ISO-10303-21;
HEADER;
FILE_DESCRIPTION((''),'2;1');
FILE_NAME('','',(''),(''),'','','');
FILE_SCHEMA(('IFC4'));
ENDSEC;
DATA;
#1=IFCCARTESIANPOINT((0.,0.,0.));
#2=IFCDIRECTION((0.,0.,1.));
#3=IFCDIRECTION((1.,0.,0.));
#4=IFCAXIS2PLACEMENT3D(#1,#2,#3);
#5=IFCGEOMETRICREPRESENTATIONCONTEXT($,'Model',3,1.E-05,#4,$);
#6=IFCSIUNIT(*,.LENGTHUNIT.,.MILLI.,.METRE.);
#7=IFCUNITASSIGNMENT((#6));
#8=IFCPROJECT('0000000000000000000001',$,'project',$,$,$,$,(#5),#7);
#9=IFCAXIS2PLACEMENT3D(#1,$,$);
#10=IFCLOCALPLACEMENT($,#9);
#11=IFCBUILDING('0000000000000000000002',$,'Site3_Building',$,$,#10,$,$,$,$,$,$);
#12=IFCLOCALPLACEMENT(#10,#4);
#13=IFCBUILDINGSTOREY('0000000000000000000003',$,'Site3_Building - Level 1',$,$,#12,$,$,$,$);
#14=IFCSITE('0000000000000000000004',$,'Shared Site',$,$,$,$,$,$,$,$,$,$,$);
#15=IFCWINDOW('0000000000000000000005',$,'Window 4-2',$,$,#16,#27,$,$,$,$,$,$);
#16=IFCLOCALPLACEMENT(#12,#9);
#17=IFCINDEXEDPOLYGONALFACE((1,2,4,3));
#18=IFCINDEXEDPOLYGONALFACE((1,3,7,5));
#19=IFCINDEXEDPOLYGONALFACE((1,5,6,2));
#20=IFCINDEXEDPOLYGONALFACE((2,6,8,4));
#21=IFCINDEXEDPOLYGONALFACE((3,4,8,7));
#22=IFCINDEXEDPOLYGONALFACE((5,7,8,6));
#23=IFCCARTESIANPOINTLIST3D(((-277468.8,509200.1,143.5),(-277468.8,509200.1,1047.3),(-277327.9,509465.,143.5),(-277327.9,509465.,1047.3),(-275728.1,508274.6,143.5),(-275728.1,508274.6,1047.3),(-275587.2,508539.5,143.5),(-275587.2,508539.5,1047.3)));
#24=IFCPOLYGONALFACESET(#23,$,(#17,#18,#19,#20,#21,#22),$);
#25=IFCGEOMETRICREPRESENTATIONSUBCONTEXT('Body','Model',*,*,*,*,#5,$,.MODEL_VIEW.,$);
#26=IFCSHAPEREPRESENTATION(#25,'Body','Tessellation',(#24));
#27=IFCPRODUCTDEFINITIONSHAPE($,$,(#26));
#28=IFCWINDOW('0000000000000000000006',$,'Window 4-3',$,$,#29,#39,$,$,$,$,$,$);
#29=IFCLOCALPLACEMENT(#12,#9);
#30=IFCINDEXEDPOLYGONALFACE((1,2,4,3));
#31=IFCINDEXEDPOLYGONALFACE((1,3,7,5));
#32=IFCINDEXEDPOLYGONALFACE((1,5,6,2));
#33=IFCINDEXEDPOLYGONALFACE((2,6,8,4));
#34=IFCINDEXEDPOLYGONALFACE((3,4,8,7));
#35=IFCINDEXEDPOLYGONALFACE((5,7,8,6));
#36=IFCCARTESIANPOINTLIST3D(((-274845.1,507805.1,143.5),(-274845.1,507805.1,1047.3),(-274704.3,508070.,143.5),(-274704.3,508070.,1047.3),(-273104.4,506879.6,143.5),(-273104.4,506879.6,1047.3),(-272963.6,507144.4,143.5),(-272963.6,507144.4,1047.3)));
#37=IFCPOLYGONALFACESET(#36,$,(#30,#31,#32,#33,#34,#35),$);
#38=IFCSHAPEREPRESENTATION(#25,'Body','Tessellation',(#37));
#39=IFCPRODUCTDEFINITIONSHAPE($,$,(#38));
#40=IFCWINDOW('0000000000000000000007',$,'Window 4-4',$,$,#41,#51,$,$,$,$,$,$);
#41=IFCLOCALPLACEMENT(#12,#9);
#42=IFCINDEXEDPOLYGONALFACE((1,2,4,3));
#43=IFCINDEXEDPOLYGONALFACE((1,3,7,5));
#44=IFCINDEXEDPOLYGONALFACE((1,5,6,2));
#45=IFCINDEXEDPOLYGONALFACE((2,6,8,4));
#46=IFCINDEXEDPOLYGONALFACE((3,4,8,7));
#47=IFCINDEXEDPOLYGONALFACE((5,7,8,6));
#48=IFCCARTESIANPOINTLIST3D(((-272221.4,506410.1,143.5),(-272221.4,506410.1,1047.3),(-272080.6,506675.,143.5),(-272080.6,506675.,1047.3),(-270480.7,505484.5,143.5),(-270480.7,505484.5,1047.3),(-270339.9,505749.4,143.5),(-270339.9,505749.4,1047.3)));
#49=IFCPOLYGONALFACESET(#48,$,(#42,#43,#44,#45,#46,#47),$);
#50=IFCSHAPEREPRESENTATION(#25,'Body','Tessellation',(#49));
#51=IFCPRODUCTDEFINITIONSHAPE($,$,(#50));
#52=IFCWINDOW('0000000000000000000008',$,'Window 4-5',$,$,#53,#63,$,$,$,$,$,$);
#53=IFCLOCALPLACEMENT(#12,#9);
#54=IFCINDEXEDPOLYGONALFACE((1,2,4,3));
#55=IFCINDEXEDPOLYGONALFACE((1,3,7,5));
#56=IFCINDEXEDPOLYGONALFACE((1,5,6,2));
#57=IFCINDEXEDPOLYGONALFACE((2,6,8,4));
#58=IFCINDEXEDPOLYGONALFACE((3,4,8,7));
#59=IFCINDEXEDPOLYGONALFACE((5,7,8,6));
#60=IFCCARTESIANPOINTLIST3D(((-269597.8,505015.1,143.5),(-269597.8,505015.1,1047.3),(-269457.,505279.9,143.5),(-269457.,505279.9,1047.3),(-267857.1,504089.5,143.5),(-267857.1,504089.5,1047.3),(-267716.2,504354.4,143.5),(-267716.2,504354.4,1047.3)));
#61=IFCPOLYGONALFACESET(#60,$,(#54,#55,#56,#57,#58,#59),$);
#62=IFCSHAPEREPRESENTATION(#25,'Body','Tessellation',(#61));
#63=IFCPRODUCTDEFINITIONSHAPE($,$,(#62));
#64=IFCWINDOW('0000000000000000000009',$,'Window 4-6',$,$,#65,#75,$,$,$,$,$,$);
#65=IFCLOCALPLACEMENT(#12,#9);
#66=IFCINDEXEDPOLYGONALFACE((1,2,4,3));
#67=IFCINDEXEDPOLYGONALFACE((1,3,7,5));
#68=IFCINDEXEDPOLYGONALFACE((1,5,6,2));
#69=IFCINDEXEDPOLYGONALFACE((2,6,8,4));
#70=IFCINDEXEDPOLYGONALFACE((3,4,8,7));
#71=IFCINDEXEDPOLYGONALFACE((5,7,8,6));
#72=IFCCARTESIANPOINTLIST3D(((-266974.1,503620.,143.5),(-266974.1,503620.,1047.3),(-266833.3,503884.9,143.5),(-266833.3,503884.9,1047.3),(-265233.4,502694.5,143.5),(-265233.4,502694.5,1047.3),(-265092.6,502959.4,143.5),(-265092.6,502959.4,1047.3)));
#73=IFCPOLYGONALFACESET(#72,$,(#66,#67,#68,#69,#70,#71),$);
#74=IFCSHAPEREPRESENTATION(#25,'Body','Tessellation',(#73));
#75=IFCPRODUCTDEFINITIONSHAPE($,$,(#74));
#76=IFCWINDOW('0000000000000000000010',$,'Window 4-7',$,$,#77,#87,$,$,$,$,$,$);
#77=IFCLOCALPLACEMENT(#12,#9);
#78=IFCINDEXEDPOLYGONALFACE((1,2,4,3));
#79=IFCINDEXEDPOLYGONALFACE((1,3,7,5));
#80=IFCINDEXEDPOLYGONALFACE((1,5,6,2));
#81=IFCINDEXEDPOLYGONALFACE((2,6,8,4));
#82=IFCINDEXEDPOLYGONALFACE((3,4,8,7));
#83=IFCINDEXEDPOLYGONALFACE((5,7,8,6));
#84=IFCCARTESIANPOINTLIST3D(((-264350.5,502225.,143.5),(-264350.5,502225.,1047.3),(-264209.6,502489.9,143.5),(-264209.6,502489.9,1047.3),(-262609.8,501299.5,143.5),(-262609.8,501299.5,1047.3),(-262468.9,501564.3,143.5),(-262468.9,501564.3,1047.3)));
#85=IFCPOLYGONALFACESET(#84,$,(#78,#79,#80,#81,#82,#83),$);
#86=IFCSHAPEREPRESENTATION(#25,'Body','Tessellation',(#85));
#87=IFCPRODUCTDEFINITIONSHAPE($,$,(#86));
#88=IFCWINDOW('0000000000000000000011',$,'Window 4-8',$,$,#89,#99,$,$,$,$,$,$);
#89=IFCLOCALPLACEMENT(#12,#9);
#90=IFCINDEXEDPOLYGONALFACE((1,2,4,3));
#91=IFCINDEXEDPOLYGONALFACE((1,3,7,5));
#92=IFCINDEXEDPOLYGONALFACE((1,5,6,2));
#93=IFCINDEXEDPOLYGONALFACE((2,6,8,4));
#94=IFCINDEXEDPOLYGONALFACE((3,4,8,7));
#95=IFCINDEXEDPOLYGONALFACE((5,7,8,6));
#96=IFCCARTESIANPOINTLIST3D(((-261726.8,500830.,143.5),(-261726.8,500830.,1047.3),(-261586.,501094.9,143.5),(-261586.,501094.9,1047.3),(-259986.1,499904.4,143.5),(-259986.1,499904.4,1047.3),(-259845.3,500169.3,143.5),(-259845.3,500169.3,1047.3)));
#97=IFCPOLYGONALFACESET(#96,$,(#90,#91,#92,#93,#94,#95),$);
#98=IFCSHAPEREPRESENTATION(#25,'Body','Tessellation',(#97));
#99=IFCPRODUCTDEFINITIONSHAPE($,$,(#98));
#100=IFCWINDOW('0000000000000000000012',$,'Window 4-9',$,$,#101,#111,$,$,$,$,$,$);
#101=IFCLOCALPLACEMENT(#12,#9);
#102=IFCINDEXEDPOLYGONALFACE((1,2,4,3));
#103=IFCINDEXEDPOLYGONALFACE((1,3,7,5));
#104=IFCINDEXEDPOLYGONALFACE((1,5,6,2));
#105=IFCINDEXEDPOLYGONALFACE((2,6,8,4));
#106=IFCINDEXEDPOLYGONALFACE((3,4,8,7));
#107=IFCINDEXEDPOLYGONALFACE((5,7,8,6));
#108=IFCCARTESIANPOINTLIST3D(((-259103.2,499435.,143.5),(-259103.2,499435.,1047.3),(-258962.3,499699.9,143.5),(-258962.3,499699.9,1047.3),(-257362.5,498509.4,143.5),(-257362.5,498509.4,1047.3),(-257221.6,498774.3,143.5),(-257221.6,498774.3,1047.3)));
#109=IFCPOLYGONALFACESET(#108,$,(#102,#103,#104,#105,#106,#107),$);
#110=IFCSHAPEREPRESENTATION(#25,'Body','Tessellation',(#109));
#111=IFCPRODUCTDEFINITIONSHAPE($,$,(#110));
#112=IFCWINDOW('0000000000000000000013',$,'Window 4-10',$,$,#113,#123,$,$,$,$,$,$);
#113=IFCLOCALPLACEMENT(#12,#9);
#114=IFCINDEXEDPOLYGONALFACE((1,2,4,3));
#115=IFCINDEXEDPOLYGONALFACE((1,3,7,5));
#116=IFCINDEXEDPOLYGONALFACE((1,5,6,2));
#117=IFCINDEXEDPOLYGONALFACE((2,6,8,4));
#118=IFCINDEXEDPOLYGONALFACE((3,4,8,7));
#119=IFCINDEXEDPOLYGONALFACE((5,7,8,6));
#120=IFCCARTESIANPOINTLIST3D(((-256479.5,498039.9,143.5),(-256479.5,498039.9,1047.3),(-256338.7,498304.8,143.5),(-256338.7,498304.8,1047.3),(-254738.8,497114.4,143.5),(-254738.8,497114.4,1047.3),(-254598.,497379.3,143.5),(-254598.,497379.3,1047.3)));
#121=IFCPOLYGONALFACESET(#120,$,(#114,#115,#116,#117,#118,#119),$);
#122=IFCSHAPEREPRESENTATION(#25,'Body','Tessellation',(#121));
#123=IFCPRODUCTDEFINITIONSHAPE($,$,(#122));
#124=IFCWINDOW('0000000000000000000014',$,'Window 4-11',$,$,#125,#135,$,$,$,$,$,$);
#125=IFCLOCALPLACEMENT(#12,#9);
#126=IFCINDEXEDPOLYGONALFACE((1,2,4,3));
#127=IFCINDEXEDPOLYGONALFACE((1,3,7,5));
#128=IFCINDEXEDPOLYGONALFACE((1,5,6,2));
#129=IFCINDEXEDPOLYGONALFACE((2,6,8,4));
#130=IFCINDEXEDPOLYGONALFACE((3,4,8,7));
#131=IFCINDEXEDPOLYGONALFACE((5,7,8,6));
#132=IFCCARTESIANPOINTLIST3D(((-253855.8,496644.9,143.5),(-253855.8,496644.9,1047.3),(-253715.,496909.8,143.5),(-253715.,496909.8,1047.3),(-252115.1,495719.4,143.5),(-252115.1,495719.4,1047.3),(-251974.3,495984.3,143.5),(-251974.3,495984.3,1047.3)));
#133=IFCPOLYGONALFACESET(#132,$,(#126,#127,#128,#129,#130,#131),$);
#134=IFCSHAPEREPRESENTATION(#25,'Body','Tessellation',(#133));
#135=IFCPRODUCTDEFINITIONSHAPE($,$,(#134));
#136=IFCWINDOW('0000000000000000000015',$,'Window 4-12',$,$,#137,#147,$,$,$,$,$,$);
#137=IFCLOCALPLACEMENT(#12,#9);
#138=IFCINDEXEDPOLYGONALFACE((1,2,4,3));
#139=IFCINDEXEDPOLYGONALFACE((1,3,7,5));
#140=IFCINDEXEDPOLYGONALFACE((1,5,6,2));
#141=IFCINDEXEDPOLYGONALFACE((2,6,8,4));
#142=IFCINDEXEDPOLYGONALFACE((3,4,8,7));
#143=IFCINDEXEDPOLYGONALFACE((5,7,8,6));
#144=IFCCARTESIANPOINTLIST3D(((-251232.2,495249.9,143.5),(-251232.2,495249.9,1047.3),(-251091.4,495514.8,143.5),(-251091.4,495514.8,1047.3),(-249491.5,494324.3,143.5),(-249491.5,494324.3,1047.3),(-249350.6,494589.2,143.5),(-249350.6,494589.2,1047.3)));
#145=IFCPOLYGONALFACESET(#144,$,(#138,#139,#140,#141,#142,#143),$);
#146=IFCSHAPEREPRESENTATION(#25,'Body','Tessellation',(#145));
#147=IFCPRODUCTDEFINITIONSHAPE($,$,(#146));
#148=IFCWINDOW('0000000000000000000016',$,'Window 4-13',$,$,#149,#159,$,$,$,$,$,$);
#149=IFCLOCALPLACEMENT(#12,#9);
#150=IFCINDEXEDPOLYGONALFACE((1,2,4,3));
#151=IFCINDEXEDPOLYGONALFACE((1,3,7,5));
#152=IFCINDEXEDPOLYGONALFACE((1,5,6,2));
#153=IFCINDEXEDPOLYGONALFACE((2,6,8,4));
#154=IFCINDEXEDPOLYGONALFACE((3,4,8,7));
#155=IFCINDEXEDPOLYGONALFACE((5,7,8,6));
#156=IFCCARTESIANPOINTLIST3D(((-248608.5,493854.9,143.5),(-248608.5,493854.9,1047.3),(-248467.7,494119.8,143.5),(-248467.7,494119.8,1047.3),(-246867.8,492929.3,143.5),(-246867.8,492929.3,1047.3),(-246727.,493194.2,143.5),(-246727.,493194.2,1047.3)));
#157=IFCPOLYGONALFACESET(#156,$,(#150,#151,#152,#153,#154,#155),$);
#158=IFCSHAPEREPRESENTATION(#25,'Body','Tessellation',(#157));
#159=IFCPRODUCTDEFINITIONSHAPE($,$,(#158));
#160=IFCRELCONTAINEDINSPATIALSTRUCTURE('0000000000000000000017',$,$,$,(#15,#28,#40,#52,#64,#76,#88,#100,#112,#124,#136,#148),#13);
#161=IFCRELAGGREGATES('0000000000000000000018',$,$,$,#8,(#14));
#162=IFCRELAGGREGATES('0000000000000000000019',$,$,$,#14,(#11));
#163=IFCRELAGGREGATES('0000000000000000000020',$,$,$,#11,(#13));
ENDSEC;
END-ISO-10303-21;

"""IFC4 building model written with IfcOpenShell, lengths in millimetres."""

from ifc_helpers import new_model, si_unit, frame, origin, origin_with_axes, place, context, subcontext, project, spatial, indexed_curve, outline, extrude, element, save


model = new_model("IFC4")

# Units and contexts
model_context = context("Model", 3, precision=1e-05, world=origin_with_axes())
body_context = subcontext(model_context, "Body", "Model", "MODEL_VIEW")
ifc_project = project(units=[si_unit("LENGTHUNIT", "METRE", prefix="MILLI")], contexts=[model_context])

# Site, building, storey
site = spatial("IfcSite", under=ifc_project, Name="Shared Site")
building_placement = place(None, origin())
building = spatial("IfcBuilding", under=site, at=building_placement, Name="Site3_Building")
storey_placement = place(building_placement, origin_with_axes())
storey = spatial("IfcBuildingStorey", under=building, at=storey_placement, Name="Site3_Building - Level 1")

# Windows
for number, where, z_axis, x_axis, name in (
    (1, (-277468.8, 509200.1, 143.5), (0.0, 0.0, 1.0), (0.882948, -0.469472, 0.0), "Window 4-2"),
    (2, (-274845.1, 507805.1, 143.5), (0.0, 0.0, 1.0), (0.882948, -0.469472, 0.0), "Window 4-3"),
    (3, (-272221.4, 506410.1, 143.5), (0.0, 0.0, 1.0), (0.882948, -0.469472, 0.0), "Window 4-4"),
    (4, (-269597.8, 505015.1, 143.5), (0.0, 0.0, 1.0), (0.882948, -0.469472, 0.0), "Window 4-5"),
    (5, (-266974.1, 503620.0, 143.5), (0.0, 0.0, 1.0), (0.882948, -0.469472, 0.0), "Window 4-6"),
    (6, (-264350.5, 502225.0, 143.5), (0.0, 0.0, 1.0), (0.882948, -0.469472, 0.0), "Window 4-7"),
    (7, (-261726.8, 500830.0, 143.5), (0.0, 0.0, 1.0), (0.882948, -0.469472, 0.0), "Window 4-8"),
    (8, (-259103.2, 499435.0, 143.5), (0.0, 0.0, 1.0), (0.882948, -0.469472, 0.0), "Window 4-9"),
    (9, (-256479.5, 498039.9, 143.5), (0.0, 0.0, 1.0), (0.882948, -0.469472, 0.0), "Window 4-10"),
    (10, (-253855.8, 496644.9, 143.5), (0.0, 0.0, 1.0), (0.882948, -0.469472, 0.0), "Window 4-11"),
    (11, (-251232.2, 495249.9, 143.5), (0.0, 0.0, 1.0), (0.882948, -0.469472, 0.0), "Window 4-12"),
    (12, (-248608.5, 493854.9, 143.5), (0.0, 0.0, 1.0), (0.882948, -0.469472, 0.0), "Window 4-13"),
):
    element("IfcWindow", number, at=place(storey_placement, frame(where, z_axis=z_axis, x_axis=x_axis)), inside=storey, Name=name, context=body_context, shape_type="SweptSolid", body=[
        extrude(outline(indexed_curve([(0.0, 0.0), (0.0, 300.0), (1971.5, 300.0), (1971.5, 0.0), (0.0, 0.0)], self_intersect=False)), origin_with_axes(), (0.0, 0.0, 1.0), 903.8),
    ])

save(model, "model.ifc")
